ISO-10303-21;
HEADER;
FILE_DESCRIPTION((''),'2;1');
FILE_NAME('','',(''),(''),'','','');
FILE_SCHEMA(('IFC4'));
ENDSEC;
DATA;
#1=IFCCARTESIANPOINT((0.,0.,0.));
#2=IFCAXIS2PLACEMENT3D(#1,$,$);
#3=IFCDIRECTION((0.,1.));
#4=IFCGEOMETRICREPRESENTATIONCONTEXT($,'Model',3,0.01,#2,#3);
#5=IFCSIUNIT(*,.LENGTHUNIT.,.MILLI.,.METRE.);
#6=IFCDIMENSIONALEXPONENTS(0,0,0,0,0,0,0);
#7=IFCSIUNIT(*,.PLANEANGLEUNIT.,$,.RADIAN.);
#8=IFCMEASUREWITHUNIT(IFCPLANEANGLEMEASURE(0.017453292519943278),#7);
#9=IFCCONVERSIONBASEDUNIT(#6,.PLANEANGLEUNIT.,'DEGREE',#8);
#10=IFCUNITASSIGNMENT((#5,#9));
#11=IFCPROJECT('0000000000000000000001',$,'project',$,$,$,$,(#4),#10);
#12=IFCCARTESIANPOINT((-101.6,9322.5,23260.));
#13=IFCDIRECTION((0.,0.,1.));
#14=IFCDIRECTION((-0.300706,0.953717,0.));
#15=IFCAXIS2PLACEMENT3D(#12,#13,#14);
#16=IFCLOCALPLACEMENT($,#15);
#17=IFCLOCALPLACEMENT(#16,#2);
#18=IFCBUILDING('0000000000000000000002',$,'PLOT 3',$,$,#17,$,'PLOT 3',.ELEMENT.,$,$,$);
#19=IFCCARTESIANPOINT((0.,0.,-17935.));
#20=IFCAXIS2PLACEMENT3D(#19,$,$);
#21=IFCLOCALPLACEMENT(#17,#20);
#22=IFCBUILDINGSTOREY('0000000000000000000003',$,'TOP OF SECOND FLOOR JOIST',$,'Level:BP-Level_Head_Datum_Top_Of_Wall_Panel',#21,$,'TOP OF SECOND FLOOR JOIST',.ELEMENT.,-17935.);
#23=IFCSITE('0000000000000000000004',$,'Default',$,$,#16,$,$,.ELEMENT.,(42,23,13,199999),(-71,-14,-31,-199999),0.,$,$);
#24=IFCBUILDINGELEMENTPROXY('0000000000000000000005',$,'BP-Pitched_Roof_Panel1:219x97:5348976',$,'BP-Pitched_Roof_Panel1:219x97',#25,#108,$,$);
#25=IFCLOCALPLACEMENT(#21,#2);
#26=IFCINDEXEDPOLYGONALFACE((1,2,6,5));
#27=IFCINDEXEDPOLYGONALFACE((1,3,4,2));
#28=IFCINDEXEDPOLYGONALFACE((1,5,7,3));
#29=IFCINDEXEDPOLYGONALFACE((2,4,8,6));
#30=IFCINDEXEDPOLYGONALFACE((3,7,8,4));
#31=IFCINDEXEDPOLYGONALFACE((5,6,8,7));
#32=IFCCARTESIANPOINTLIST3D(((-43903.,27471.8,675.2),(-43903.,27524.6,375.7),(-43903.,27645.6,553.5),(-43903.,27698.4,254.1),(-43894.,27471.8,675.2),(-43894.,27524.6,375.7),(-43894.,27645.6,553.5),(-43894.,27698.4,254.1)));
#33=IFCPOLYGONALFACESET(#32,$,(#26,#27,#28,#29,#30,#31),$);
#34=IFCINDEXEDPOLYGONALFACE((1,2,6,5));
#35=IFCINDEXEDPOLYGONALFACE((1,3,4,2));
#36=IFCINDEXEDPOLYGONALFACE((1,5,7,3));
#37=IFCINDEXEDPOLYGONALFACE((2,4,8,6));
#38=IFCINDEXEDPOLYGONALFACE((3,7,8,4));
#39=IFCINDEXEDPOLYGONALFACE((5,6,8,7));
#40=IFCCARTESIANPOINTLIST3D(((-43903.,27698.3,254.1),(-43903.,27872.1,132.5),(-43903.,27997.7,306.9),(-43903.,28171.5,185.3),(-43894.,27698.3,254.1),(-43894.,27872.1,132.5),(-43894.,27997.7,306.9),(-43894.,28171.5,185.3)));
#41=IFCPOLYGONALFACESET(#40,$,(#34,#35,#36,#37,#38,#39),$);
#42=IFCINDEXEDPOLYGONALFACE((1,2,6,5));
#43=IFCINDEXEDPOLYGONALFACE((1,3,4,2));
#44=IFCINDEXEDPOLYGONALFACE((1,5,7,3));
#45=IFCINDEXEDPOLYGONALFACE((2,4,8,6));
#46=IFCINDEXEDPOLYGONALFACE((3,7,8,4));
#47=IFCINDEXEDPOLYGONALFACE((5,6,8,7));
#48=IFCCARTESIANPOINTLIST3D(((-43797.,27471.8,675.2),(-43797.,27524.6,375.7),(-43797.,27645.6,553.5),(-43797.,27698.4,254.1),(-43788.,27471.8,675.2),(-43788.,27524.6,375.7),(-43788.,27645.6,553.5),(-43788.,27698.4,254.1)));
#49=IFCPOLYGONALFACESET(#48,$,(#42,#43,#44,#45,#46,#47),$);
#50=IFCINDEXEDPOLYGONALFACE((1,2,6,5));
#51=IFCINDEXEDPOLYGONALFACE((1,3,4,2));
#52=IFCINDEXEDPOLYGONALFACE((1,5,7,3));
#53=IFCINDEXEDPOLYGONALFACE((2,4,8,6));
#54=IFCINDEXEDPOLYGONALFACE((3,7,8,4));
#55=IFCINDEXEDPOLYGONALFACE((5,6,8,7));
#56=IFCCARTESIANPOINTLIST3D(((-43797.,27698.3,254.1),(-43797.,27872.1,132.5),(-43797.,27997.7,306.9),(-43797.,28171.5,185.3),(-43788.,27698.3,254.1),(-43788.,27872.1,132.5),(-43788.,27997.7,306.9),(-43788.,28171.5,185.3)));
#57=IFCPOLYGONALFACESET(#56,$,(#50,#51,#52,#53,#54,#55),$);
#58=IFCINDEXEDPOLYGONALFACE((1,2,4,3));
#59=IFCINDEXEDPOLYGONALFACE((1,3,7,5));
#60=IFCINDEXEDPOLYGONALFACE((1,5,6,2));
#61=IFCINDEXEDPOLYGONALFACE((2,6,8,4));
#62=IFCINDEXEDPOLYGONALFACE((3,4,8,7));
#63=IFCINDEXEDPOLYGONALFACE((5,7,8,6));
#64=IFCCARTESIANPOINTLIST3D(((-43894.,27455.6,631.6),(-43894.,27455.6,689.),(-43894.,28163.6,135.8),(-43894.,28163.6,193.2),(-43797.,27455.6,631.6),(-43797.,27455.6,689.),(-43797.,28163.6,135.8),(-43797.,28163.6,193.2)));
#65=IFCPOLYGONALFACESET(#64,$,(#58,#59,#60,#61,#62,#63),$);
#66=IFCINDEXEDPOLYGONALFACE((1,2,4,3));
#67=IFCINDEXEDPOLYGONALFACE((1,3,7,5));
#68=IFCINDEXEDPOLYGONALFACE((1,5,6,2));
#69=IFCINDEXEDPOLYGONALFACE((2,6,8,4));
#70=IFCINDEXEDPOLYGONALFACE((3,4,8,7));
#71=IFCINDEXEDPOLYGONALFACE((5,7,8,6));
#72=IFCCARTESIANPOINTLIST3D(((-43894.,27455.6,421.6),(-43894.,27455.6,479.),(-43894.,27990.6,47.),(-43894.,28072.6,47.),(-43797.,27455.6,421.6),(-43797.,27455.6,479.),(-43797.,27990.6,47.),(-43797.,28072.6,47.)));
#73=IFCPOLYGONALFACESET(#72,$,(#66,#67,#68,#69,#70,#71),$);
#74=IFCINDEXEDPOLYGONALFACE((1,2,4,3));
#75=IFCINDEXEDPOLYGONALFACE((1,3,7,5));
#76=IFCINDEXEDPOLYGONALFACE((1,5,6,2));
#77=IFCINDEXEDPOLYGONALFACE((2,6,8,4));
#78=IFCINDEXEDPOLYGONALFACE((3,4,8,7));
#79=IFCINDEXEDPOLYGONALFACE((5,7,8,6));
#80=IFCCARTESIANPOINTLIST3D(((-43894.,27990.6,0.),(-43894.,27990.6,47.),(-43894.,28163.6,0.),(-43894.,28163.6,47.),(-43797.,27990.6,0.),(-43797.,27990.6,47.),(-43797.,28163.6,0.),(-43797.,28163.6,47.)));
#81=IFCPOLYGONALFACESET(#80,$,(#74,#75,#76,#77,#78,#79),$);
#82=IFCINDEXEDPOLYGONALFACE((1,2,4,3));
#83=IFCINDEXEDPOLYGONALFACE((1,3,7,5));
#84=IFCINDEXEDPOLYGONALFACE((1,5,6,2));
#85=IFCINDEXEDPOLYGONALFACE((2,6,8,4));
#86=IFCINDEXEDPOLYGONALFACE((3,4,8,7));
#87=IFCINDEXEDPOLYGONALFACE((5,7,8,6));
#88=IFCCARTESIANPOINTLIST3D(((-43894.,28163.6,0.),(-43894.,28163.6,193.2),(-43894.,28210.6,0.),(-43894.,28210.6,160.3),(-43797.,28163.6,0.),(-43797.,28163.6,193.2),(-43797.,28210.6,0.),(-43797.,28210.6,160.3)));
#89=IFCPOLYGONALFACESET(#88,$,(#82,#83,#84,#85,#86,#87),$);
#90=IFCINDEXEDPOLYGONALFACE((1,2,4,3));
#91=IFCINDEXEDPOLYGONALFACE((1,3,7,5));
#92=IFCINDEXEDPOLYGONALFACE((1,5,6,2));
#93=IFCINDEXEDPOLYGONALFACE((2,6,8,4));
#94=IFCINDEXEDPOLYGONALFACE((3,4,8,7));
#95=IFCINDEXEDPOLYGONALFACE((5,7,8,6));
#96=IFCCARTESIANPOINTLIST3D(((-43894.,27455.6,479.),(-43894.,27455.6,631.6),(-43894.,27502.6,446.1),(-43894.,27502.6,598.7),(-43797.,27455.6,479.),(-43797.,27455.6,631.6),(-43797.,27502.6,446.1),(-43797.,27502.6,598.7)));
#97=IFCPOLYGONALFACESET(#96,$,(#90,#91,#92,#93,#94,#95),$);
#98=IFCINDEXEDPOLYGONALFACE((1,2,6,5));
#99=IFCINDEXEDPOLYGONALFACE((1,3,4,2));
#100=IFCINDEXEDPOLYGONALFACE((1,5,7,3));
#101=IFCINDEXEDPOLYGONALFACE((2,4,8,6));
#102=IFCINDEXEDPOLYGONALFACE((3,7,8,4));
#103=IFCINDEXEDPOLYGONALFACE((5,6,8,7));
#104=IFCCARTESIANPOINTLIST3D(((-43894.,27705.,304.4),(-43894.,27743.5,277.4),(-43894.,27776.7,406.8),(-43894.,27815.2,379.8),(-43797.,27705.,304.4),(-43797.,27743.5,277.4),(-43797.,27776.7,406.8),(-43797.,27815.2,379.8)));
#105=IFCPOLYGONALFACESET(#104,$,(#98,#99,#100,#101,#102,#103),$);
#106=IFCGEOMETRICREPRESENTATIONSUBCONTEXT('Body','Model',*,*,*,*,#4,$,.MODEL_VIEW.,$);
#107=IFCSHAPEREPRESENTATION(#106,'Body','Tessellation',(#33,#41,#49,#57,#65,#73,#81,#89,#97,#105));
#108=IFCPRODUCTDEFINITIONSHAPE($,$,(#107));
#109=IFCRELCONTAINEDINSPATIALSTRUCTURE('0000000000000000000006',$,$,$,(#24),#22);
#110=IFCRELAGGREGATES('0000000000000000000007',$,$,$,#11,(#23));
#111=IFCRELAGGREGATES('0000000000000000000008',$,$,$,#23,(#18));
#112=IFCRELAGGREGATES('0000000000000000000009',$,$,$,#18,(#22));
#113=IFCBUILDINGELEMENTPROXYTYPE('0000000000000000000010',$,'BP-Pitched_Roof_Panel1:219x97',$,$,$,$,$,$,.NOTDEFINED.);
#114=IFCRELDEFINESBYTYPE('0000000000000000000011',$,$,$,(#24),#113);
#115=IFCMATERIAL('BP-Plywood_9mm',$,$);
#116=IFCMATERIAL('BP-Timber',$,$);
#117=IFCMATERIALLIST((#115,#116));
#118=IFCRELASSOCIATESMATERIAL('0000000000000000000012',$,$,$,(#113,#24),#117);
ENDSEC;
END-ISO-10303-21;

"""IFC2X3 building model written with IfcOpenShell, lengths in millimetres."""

from ifc_helpers import new_model, entity, si_unit, converted_unit, direction, frame, frame_2d, origin, origin_2d_with_axis, place, context, subcontext, project, spatial, polyline, rectangle, outline, extrude, source, transform, mapped, material, material_list, type_object, type_shapes, element, save


model = new_model("IFC2X3")

# Units and contexts
model_context = context("Model", 3, precision=0.01, world=origin(), true_north=direction((0.0, 1.0)))
body_context = subcontext(model_context, "Body", "Model", "MODEL_VIEW")
ifc_project = project(units=[si_unit("LENGTHUNIT", "METRE", prefix="MILLI"), converted_unit("PLANEANGLEUNIT", "DEGREE", entity("IfcPlaneAngleMeasure", 0.017453292519943278), si_unit("PLANEANGLEUNIT", "RADIAN"), dimensions=[0, 0, 0, 0, 0, 0, 0])], contexts=[model_context])

# Site, building, storey
site_placement = place(None, frame((-101.6, 9322.5, 23260.0), z_axis=(0.0, 0.0, 1.0), x_axis=(-0.300706, 0.953717, 0.0)))
site = spatial("IfcSite", under=ifc_project, at=site_placement, Name="Default", CompositionType="ELEMENT", RefLatitude=(42, 23, 13, 199999), RefLongitude=(-71, -14, -31, -199999), RefElevation=0.0)
building_placement = place(site_placement, origin())
building = spatial("IfcBuilding", under=site, at=building_placement, Name="PLOT 3", LongName="PLOT 3", CompositionType="ELEMENT")
storey_placement = place(building_placement, frame((0.0, 0.0, -17935.0)))
storey = spatial("IfcBuildingStorey", under=building, at=storey_placement, Name="TOP OF SECOND FLOOR JOIST", ObjectType="Level:BP-Level_Head_Datum_Top_Of_Wall_Panel", LongName="TOP OF SECOND FLOOR JOIST", CompositionType="ELEMENT", Elevation=-17935.0)

# Building element proxy
ifc_material_1 = material(Name="BP-Timber")
ifc_material_2 = material(Name="BP-Plywood_9mm")
ifc_material_list = material_list([ifc_material_2, ifc_material_1])
building_element_proxy_type_1 = type_object("IfcBuildingElementProxyType", Name="BP-Pitched_Roof_Panel1:219x97", PredefinedType="NOTDEFINED", material=ifc_material_list)
shared_shape_1 = source(origin(), body_context, "Body", "SweptSolid", [
    extrude(outline(polyline([(1.4, -107.5), (213.6, -107.5), (-1.4, 107.5), (-213.6, 107.5), (1.4, -107.5)])), frame((-2796.8, -3956.0, 464.6), z_axis=(0.0, 1.0, 0.0), x_axis=(-0.819152, 0.0, -0.573576)), (0.0, 0.0, 1.0), 9.0),
    extrude(outline(polyline([(-77.0, -75.0), (227.0, -75.0), (77.0, 75.0), (-227.0, 75.0), (-77.0, -75.0)])), frame((-3146.6, -3956.0, 219.7), z_axis=(0.0, 1.0, 0.0), x_axis=(-0.984808, 0.0, 0.173648)), (0.0, 0.0, 1.0), 9.0),
    extrude(outline(polyline([(1.4, -107.5), (213.6, -107.5), (-1.4, 107.5), (-213.6, 107.5), (1.4, -107.5)])), frame((-2796.8, -3850.0, 464.6), z_axis=(0.0, 1.0, 0.0), x_axis=(-0.819152, 0.0, -0.573576)), (0.0, 0.0, 1.0), 9.0),
    extrude(outline(polyline([(-77.0, -75.0), (227.0, -75.0), (77.0, 75.0), (-227.0, 75.0), (-77.0, -75.0)])), frame((-3146.6, -3850.0, 219.7), z_axis=(0.0, 1.0, 0.0), x_axis=(-0.984808, 0.0, 0.173648)), (0.0, 0.0, 1.0), 9.0),
    extrude(outline(polyline([(-276.6, -354.0), (-219.2, -354.0), (276.6, 354.0), (219.2, 354.0), (-276.6, -354.0)])), frame((-3021.3, -3947.0, 412.4), z_axis=(0.0, 1.0, 0.0), x_axis=(0.0, 0.0, -1.0)), (0.0, 0.0, 1.0), 97.0),
    extrude(outline(polyline([(-230.3, -288.0), (-173.0, -288.0), (201.6, 247.0), (201.6, 329.0), (-230.3, -288.0)])), frame((-2955.3, -3947.0, 248.6), z_axis=(0.0, 1.0, 0.0), x_axis=(0.0, 0.0, -1.0)), (0.0, 0.0, 1.0), 97.0),
    extrude(rectangle(XDim=173.0, YDim=97.0, at=origin_2d_with_axis()), frame((-3288.8, -3898.5, 0.0), z_axis=(0.0, 0.0, 1.0), x_axis=(-1.0, 0.0, 0.0)), (0.0, 0.0, 1.0), 47.0),
    extrude(outline(polyline([(22.0, -72.4), (79.4, -72.4), (-31.4, 85.9), (-69.9, 58.9), (22.0, -72.4)])), frame((-3398.8, -3947.0, 88.4), z_axis=(0.0, 1.0, 0.0), x_axis=(0.819152, 0.0, 0.573576)), (0.0, 0.0, 1.0), 97.0),
    extrude(outline(polyline([(15.1, -62.5), (72.5, -62.5), (-15.1, 62.5), (-72.5, 62.5), (15.1, -62.5)])), frame((-2690.8, -3947.0, 538.8), z_axis=(0.0, 1.0, 0.0), x_axis=(0.819152, 0.0, 0.573576)), (0.0, 0.0, 1.0), 97.0),
    extrude(rectangle(XDim=47.0, YDim=97.0, at=frame_2d((0.0, 0.0), x_axis=(1.0, 0.0))), frame((-2935.9, -3898.5, 290.9), z_axis=(-0.573576, 0.0, 0.819152), x_axis=(-0.819152, 0.0, -0.573576)), (0.0, 0.0, 1.0), 125.0),
])
type_shapes(building_element_proxy_type_1, [shared_shape_1])
for number, where, z_axis, x_axis, name in (
    (1, (-39947.0, 24788.3, 0.0), (0.0, 0.0, 1.0), (0.0, -1.0, 0.0), "BP-Pitched_Roof_Panel1:219x97:5348976"),
):
    element("IfcBuildingElementProxy", number, at=place(storey_placement, frame(where, z_axis=z_axis, x_axis=x_axis)), inside=storey, type_object=building_element_proxy_type_1, material=ifc_material_list, Name=name, ObjectType="BP-Pitched_Roof_Panel1:219x97", context=body_context, shape_type="MappedRepresentation", body=[
        mapped(shared_shape_1, transform((0.0, 0.0, 0.0), scale=1.0)),
    ])

save(model, "model.ifc")
